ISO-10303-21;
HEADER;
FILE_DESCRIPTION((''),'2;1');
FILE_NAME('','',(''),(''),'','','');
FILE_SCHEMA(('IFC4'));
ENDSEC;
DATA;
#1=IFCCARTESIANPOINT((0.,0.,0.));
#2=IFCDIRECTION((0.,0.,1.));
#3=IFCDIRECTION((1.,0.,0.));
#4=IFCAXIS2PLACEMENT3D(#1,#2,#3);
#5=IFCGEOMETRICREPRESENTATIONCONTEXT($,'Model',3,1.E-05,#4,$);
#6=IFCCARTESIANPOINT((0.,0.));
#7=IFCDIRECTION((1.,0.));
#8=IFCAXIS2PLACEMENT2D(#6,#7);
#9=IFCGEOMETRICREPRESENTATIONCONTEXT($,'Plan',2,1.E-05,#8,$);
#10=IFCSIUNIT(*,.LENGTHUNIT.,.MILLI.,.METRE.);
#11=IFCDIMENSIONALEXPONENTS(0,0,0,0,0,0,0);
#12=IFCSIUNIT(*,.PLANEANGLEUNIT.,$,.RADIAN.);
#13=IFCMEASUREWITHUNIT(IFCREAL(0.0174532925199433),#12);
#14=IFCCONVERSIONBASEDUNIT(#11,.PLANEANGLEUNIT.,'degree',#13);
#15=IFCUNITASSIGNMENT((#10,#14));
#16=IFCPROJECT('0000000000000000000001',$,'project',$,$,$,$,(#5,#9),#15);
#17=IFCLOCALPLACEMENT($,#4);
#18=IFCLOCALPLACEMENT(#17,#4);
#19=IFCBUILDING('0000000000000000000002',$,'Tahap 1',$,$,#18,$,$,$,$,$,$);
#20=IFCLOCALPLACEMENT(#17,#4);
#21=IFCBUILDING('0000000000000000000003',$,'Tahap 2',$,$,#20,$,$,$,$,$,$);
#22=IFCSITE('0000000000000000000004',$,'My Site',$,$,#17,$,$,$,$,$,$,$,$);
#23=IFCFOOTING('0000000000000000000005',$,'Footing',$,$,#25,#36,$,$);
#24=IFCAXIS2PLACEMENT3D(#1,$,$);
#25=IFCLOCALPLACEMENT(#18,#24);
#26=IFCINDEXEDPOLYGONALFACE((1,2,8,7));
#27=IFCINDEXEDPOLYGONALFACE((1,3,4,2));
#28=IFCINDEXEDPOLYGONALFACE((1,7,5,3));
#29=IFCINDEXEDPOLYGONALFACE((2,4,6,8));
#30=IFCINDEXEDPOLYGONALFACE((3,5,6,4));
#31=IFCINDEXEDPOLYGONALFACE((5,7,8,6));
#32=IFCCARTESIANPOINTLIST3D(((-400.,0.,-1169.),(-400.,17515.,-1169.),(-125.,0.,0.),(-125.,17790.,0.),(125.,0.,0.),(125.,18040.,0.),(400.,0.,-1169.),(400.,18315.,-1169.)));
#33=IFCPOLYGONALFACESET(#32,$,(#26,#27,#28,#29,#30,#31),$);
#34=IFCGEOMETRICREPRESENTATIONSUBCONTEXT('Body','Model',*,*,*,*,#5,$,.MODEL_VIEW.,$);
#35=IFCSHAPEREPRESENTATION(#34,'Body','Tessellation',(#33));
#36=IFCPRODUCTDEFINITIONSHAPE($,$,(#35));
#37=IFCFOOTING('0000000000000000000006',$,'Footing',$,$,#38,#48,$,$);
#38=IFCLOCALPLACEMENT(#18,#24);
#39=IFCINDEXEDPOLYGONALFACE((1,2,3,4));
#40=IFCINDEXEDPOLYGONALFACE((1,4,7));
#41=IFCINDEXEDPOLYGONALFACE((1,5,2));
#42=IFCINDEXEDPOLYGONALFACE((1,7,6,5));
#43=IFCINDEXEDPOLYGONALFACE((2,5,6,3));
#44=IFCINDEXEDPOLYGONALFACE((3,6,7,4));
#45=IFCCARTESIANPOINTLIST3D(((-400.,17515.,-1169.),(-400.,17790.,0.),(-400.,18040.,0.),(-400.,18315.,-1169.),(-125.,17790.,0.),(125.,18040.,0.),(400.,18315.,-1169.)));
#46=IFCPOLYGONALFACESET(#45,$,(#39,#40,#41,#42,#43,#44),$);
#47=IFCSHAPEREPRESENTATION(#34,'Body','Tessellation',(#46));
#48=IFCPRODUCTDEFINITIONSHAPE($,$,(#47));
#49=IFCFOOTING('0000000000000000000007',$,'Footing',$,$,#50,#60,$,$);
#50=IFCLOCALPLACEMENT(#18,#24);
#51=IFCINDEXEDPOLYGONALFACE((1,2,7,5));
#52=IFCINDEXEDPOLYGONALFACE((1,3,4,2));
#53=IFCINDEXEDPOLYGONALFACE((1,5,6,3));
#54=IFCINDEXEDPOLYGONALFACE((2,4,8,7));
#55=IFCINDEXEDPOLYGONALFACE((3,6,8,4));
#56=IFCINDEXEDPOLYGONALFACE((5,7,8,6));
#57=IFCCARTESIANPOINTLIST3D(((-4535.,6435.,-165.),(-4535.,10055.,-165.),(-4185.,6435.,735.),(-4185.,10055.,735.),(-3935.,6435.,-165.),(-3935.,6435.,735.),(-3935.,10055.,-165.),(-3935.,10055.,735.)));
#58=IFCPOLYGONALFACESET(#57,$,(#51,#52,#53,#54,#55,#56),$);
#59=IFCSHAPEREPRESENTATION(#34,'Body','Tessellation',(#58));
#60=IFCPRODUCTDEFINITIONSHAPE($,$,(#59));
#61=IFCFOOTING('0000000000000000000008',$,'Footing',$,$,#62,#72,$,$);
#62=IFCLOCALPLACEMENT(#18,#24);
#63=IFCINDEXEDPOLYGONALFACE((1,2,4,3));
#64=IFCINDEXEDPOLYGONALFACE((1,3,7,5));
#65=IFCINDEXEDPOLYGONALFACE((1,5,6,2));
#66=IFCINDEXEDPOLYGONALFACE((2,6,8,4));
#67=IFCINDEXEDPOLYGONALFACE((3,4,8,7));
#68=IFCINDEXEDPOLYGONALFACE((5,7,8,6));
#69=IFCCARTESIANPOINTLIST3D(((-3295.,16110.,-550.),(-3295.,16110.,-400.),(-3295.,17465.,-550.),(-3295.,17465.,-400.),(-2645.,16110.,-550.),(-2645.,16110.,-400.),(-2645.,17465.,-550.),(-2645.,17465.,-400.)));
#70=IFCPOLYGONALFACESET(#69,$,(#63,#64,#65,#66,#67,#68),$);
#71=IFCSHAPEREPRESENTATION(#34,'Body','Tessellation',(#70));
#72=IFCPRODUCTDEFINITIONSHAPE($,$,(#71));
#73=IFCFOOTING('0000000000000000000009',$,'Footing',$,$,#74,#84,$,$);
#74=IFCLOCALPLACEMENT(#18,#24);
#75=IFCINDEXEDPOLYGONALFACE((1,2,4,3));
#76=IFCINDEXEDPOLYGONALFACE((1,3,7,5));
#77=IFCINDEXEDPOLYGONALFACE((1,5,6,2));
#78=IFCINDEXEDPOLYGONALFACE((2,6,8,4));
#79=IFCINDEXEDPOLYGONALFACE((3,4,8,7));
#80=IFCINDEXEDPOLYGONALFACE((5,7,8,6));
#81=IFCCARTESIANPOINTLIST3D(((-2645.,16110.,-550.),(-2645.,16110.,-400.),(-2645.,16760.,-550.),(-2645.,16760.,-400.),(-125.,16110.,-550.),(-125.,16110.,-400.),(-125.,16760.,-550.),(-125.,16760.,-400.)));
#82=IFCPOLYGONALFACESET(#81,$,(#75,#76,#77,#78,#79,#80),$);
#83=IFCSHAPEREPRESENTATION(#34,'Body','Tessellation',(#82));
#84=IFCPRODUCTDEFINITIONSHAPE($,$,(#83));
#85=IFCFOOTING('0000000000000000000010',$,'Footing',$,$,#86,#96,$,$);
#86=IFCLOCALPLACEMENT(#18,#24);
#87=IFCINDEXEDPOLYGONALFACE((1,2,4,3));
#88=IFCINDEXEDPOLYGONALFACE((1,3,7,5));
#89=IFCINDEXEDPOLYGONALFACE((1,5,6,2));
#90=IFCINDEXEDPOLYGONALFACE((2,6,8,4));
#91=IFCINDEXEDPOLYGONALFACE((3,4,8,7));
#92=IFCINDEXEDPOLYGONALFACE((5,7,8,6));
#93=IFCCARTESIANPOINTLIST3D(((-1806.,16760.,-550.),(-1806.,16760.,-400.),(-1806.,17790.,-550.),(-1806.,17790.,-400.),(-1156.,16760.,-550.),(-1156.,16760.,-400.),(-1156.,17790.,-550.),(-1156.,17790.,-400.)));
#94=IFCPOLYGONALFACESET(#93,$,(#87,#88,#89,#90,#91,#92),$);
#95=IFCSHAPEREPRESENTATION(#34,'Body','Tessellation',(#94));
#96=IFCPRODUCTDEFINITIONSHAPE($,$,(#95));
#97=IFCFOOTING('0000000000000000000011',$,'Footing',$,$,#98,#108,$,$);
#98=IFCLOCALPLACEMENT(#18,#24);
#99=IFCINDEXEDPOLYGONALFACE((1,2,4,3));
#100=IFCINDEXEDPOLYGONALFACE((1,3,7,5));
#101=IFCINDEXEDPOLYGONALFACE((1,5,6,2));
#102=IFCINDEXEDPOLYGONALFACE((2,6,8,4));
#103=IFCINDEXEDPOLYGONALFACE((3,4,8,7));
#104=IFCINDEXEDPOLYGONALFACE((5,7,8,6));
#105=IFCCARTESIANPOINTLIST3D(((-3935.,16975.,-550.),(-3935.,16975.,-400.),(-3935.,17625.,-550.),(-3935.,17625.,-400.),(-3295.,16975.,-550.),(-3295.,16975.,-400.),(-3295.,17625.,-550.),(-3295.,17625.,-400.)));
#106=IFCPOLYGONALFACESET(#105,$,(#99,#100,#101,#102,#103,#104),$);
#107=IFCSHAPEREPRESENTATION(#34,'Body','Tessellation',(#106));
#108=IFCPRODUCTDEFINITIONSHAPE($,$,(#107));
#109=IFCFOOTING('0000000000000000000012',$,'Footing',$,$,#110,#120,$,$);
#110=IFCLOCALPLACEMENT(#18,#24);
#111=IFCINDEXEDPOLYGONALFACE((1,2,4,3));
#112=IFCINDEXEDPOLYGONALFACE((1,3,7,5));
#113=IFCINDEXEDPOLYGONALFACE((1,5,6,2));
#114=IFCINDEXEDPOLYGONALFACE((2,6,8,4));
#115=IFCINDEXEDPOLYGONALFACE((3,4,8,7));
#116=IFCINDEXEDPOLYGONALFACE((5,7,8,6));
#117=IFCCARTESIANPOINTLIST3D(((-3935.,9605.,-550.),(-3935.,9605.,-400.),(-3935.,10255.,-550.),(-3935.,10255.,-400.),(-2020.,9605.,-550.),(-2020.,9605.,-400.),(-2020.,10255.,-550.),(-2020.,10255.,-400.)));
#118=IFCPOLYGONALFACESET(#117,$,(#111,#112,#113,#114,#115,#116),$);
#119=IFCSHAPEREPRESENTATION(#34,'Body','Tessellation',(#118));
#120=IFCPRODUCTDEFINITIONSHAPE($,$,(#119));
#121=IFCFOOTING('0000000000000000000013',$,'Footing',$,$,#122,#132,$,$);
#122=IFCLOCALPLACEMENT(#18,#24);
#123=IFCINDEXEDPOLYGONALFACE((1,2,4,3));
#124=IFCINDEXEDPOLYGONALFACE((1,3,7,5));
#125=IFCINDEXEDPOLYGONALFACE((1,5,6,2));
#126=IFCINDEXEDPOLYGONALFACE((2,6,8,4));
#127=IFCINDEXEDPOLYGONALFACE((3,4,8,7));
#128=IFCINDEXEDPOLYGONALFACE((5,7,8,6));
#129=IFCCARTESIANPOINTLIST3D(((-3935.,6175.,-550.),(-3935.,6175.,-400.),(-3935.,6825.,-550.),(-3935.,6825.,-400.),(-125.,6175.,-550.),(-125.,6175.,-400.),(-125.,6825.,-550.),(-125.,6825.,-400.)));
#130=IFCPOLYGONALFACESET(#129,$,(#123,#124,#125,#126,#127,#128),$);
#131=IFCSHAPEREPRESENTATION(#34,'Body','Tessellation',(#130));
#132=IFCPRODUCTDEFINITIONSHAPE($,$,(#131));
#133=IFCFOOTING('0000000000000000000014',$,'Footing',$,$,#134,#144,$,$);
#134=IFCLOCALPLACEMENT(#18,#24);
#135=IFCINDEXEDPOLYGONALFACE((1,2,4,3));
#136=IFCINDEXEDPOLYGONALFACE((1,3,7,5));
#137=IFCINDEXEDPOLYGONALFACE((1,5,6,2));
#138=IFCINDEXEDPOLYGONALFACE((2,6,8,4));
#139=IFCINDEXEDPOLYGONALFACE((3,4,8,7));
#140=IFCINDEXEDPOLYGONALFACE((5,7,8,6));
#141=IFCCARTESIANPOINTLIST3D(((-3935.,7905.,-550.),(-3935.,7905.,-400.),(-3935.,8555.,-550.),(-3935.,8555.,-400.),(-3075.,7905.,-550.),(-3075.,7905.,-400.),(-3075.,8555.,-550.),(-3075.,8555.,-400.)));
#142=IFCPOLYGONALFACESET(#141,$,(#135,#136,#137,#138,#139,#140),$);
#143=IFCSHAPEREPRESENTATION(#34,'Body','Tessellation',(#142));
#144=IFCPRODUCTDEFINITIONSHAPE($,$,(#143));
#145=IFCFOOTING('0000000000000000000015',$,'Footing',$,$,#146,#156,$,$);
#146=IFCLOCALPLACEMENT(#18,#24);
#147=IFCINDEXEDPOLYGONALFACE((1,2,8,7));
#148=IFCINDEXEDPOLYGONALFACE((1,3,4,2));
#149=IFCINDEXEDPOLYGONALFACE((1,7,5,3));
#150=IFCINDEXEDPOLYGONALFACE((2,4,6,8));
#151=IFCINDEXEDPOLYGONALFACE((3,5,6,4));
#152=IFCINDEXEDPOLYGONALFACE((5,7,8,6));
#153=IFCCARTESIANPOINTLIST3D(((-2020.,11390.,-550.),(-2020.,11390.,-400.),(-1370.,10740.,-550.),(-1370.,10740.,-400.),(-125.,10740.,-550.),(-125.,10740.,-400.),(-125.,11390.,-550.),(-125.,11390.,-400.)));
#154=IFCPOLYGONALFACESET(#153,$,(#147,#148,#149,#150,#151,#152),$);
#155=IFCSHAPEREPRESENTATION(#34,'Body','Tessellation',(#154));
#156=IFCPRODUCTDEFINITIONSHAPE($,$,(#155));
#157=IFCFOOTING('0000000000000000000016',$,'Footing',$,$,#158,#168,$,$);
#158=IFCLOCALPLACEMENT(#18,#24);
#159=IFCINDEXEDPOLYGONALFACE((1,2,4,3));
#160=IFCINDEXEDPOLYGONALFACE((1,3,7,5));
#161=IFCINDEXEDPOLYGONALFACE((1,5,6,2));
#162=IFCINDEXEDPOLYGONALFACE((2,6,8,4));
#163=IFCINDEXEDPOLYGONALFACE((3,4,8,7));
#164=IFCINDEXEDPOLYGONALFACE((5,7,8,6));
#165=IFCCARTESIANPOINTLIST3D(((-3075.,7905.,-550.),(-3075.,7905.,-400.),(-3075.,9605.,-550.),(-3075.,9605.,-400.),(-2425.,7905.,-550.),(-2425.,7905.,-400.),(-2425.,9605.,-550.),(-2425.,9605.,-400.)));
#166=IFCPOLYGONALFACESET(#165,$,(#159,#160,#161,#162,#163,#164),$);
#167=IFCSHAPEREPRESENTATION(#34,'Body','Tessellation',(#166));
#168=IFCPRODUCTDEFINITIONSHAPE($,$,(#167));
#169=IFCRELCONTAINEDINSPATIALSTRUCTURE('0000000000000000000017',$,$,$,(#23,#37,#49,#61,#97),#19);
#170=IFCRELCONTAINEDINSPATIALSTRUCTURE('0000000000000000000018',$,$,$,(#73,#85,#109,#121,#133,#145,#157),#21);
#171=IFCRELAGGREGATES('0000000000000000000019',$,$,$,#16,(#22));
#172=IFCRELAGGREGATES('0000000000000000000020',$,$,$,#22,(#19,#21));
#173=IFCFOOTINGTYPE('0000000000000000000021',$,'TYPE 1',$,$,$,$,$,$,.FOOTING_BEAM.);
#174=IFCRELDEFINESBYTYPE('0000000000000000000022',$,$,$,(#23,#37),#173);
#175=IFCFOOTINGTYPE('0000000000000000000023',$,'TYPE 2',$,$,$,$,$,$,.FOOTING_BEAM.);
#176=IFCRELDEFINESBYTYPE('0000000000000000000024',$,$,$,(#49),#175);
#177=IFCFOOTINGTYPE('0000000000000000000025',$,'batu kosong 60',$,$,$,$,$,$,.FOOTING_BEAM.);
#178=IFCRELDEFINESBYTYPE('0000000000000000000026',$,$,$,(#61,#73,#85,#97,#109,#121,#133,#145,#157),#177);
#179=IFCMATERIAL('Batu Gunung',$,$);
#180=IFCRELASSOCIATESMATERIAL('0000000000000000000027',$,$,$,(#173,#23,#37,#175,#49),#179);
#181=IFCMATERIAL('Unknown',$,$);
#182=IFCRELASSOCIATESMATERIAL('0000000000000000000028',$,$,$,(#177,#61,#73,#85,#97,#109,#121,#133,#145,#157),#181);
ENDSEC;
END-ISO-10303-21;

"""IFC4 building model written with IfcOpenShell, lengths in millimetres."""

from ifc_helpers import new_model, entity, si_unit, converted_unit, frame, origin_with_axes, origin_2d_with_axis, place, context, subcontext, project, spatial, indexed_curve, rectangle, outline, extrude, clip, halfspace, material, material_profile, profile_set, profile_usage, type_object, element, save


model = new_model("IFC4")

# Units and contexts
model_context = context("Model", 3, precision=1e-05, world=origin_with_axes())
plan_context = context("Plan", 2, precision=1e-05, world=origin_2d_with_axis())
body_context = subcontext(model_context, "Body", "Model", "MODEL_VIEW")
ifc_project = project(units=[si_unit("LENGTHUNIT", "METRE", prefix="MILLI"), converted_unit("PLANEANGLEUNIT", "degree", entity("IfcReal", 0.0174532925199433), si_unit("PLANEANGLEUNIT", "RADIAN"), dimensions=[0, 0, 0, 0, 0, 0, 0])], contexts=[model_context, plan_context])

# Site, building
site_placement = place(None, origin_with_axes())
site = spatial("IfcSite", under=ifc_project, at=site_placement, Name="My Site")
building_1_placement = place(site_placement, origin_with_axes())
building_1 = spatial("IfcBuilding", under=site, at=building_1_placement, Name="Tahap 1")

# Footings
ifc_material_1 = material(Name="Batu Gunung")
ifc_material_profile_1 = material_profile(ifc_material_1, outline(indexed_curve([(-125.0, 0.0), (125.0, 0.0), (400.0, -1169.0), (-400.0, -1169.0), (-125.0, 0.0)])))
ifc_profile_set_1 = profile_set([ifc_material_profile_1])
ifc_profile_usage_1 = profile_usage(ifc_profile_set_1, cardinal=5)
footing_type_1 = type_object("IfcFootingType", Name="TYPE 1", PredefinedType="FOOTING_BEAM", material=ifc_profile_set_1)
footing_1_placement = place(building_1_placement, frame((0.0, 0.0, 0.0), z_axis=(0.0, 1.0, 0.0), x_axis=(-1.0, 0.0, 0.0)))
element("IfcFooting", 1, at=footing_1_placement, inside=building_1, type_object=footing_type_1, material=ifc_profile_usage_1, Name="Footing", context=body_context, shape_type="Clipping", body=[
    clip(extrude(outline(indexed_curve([(-125.0, 0.0), (125.0, 0.0), (400.0, -1169.0), (-400.0, -1169.0), (-125.0, 0.0)])), origin_with_axes(), (0.0, 0.0, 1.0), 18315.0), halfspace(frame((-400.0, 0.0, 18315.0), z_axis=(0.707107, 0.0, 0.707107), x_axis=(0.0, -1.0, 0.0)), False)),
])
ifc_profile_usage_2 = profile_usage(ifc_profile_set_1, cardinal=5)
footing_2_placement = place(building_1_placement, frame((400.0, 17915.0, 0.0), z_axis=(-1.0, 0.0, 0.0), x_axis=(0.0, -1.0, 0.0)))
element("IfcFooting", 2, at=footing_2_placement, inside=building_1, type_object=footing_type_1, material=ifc_profile_usage_2, Name="Footing", context=body_context, shape_type="Clipping", body=[
    clip(extrude(outline(indexed_curve([(-125.0, 0.0), (125.0, 0.0), (400.0, -1169.0), (-400.0, -1169.0), (-125.0, 0.0)])), origin_with_axes(), (0.0, 0.0, 1.0), 800.0), halfspace(frame((-400.0, 0.0, 0.0), z_axis=(0.707107, 0.0, -0.707106), x_axis=(0.0, -1.0, 0.0)), False)),
])
ifc_material_profile_2 = material_profile(ifc_material_1, outline(indexed_curve([(-125.0, -900.0), (475.0, -900.0), (125.0, 0.0), (-125.0, 0.0), (-125.0, -900.0)])))
ifc_profile_set_2 = profile_set([ifc_material_profile_2])
ifc_profile_usage_3 = profile_usage(ifc_profile_set_2, cardinal=5)
footing_type_2 = type_object("IfcFootingType", Name="TYPE 2", PredefinedType="FOOTING_BEAM", material=ifc_profile_set_2)
footing_3_placement = place(building_1_placement, frame((-4060.0, 6435.0, 735.0), z_axis=(0.0, 1.0, 0.0), x_axis=(-1.0, 0.0, 0.0)))
element("IfcFooting", 3, at=footing_3_placement, inside=building_1, type_object=footing_type_2, material=ifc_profile_usage_3, Name="Footing", context=body_context, shape_type="SweptSolid", body=[
    extrude(outline(indexed_curve([(-125.0, -900.0), (475.0, -900.0), (125.0, 0.0), (-125.0, 0.0), (-125.0, -900.0)])), origin_with_axes(), (0.0, 0.0, 1.0), 3620.0),
])
ifc_material_2 = material(Name="Unknown")
ifc_material_profile_3 = material_profile(ifc_material_2, rectangle(XDim=650.0, YDim=150.0, kind="CURVE"))
ifc_profile_set_3 = profile_set([ifc_material_profile_3])
ifc_profile_usage_4 = profile_usage(ifc_profile_set_3, cardinal=8)
footing_type_3 = type_object("IfcFootingType", Name="batu kosong 60", PredefinedType="FOOTING_BEAM", material=ifc_profile_set_3)
footing_4_placement = place(building_1_placement, frame((-2970.0, 16110.0, -400.0), z_axis=(0.0, 1.0, 0.0), x_axis=(-1.0, 0.0, 0.0)))
element("IfcFooting", 4, at=footing_4_placement, inside=building_1, type_object=footing_type_3, material=ifc_profile_usage_4, Name="Footing", context=body_context, shape_type="SweptSolid", body=[
    extrude(rectangle(XDim=650.0, YDim=150.0, kind="CURVE"), frame((0.0, -75.0, 0.0), z_axis=(0.0, 0.0, 1.0), x_axis=(1.0, 0.0, 0.0)), (0.0, 0.0, 1.0), 1355.0),
])

# Shared definitions
building_2_placement = place(site_placement, origin_with_axes())
building_2 = spatial("IfcBuilding", under=site, at=building_2_placement, Name="Tahap 2")

# Footings
ifc_profile_usage_5 = profile_usage(ifc_profile_set_3, cardinal=8)
footing_5_placement = place(building_2_placement, frame((-125.0, 16435.0, -400.0), z_axis=(-1.0, 0.0, 0.0), x_axis=(0.0, -1.0, 0.0)))
element("IfcFooting", 5, at=footing_5_placement, inside=building_2, type_object=footing_type_3, material=ifc_profile_usage_5, Name="Footing", context=body_context, shape_type="SweptSolid", body=[
    extrude(rectangle(XDim=650.0, YDim=150.0, kind="CURVE"), frame((0.0, -75.0, 0.0), z_axis=(0.0, 0.0, 1.0), x_axis=(1.0, 0.0, 0.0)), (0.0, 0.0, 1.0), 2520.0),
])
ifc_profile_usage_6 = profile_usage(ifc_profile_set_3, cardinal=8)
footing_6_placement = place(building_2_placement, frame((-1481.0, 16760.0, -400.0), z_axis=(0.0, 1.0, 0.0), x_axis=(-1.0, 0.0, 0.0)))
element("IfcFooting", 6, at=footing_6_placement, inside=building_2, type_object=footing_type_3, material=ifc_profile_usage_6, Name="Footing", context=body_context, shape_type="SweptSolid", body=[
    extrude(rectangle(XDim=650.0, YDim=150.0, kind="CURVE"), frame((0.0, -75.0, 0.0), z_axis=(0.0, 0.0, 1.0), x_axis=(1.0, 0.0, 0.0)), (0.0, 0.0, 1.0), 1030.0),
])
ifc_profile_usage_7 = profile_usage(ifc_profile_set_3, cardinal=8)
footing_7_placement = place(building_1_placement, frame((-3295.0, 17300.0, -400.0), z_axis=(-1.0, 0.0, 0.0), x_axis=(0.0, -1.0, 0.0)))
element("IfcFooting", 7, at=footing_7_placement, inside=building_1, type_object=footing_type_3, material=ifc_profile_usage_7, Name="Footing", context=body_context, shape_type="SweptSolid", body=[
    extrude(rectangle(XDim=650.0, YDim=150.0, kind="CURVE"), frame((0.0, -75.0, 0.0), z_axis=(0.0, 0.0, 1.0), x_axis=(1.0, 0.0, 0.0)), (0.0, 0.0, 1.0), 640.0),
])
ifc_profile_usage_8 = profile_usage(ifc_profile_set_3, cardinal=8)
footing_8_placement = place(building_2_placement, frame((-2020.0, 9930.0, -400.0), z_axis=(-1.0, 0.0, 0.0), x_axis=(0.0, -1.0, 0.0)))
element("IfcFooting", 8, at=footing_8_placement, inside=building_2, type_object=footing_type_3, material=ifc_profile_usage_8, Name="Footing", context=body_context, shape_type="SweptSolid", body=[
    extrude(rectangle(XDim=650.0, YDim=150.0, kind="CURVE"), frame((0.0, -75.0, 0.0), z_axis=(0.0, 0.0, 1.0), x_axis=(1.0, 0.0, 0.0)), (0.0, 0.0, 1.0), 1915.0),
])
ifc_profile_usage_9 = profile_usage(ifc_profile_set_3, cardinal=8)
footing_9_placement = place(building_2_placement, frame((-3935.0, 6500.0, -400.0), z_axis=(1.0, 0.0, 0.0), x_axis=(0.0, 1.0, 0.0)))
element("IfcFooting", 9, at=footing_9_placement, inside=building_2, type_object=footing_type_3, material=ifc_profile_usage_9, Name="Footing", context=body_context, shape_type="SweptSolid", body=[
    extrude(rectangle(XDim=650.0, YDim=150.0, kind="CURVE"), frame((0.0, -75.0, 0.0), z_axis=(0.0, 0.0, 1.0), x_axis=(1.0, 0.0, 0.0)), (0.0, 0.0, 1.0), 3810.0),
])
ifc_profile_usage_10 = profile_usage(ifc_profile_set_3, cardinal=8)
footing_10_placement = place(building_2_placement, frame((-3935.0, 8230.0, -400.0), z_axis=(1.0, 0.0, 0.0), x_axis=(0.0, 1.0, 0.0)))
element("IfcFooting", 10, at=footing_10_placement, inside=building_2, type_object=footing_type_3, material=ifc_profile_usage_10, Name="Footing", context=body_context, shape_type="SweptSolid", body=[
    extrude(rectangle(XDim=650.0, YDim=150.0, kind="CURVE"), frame((0.0, -75.0, 0.0), z_axis=(0.0, 0.0, 1.0), x_axis=(1.0, 0.0, 0.0)), (0.0, 0.0, 1.0), 860.0),
])
ifc_profile_usage_11 = profile_usage(ifc_profile_set_3)
footing_11_placement = place(building_2_placement, frame((-125.0, 11065.0, -475.0), z_axis=(-1.0, 0.0, 0.0), x_axis=(0.0, -1.0, 0.0)))
element("IfcFooting", 11, at=footing_11_placement, inside=building_2, type_object=footing_type_3, material=ifc_profile_usage_11, Name="Footing", context=body_context, shape_type="Clipping", body=[
    clip(extrude(rectangle(XDim=650.0, YDim=150.0, kind="CURVE"), origin_with_axes(), (0.0, 0.0, 1.0), 1895.0), halfspace(frame((-325.0, 475.0, 1895.0), z_axis=(0.707107, 0.0, 0.707107), x_axis=(0.0, -1.0, 0.0)), False)),
])
ifc_profile_usage_12 = profile_usage(ifc_profile_set_3, cardinal=8)
footing_12_placement = place(building_2_placement, frame((-2750.0, 7905.0, -400.0), z_axis=(0.0, 1.0, 0.0), x_axis=(-1.0, 0.0, 0.0)))
element("IfcFooting", 12, at=footing_12_placement, inside=building_2, type_object=footing_type_3, material=ifc_profile_usage_12, Name="Footing", context=body_context, shape_type="SweptSolid", body=[
    extrude(rectangle(XDim=650.0, YDim=150.0, kind="CURVE"), frame((0.0, -75.0, 0.0), z_axis=(0.0, 0.0, 1.0), x_axis=(1.0, 0.0, 0.0)), (0.0, 0.0, 1.0), 1700.0),
])

save(model, "model.ifc")
